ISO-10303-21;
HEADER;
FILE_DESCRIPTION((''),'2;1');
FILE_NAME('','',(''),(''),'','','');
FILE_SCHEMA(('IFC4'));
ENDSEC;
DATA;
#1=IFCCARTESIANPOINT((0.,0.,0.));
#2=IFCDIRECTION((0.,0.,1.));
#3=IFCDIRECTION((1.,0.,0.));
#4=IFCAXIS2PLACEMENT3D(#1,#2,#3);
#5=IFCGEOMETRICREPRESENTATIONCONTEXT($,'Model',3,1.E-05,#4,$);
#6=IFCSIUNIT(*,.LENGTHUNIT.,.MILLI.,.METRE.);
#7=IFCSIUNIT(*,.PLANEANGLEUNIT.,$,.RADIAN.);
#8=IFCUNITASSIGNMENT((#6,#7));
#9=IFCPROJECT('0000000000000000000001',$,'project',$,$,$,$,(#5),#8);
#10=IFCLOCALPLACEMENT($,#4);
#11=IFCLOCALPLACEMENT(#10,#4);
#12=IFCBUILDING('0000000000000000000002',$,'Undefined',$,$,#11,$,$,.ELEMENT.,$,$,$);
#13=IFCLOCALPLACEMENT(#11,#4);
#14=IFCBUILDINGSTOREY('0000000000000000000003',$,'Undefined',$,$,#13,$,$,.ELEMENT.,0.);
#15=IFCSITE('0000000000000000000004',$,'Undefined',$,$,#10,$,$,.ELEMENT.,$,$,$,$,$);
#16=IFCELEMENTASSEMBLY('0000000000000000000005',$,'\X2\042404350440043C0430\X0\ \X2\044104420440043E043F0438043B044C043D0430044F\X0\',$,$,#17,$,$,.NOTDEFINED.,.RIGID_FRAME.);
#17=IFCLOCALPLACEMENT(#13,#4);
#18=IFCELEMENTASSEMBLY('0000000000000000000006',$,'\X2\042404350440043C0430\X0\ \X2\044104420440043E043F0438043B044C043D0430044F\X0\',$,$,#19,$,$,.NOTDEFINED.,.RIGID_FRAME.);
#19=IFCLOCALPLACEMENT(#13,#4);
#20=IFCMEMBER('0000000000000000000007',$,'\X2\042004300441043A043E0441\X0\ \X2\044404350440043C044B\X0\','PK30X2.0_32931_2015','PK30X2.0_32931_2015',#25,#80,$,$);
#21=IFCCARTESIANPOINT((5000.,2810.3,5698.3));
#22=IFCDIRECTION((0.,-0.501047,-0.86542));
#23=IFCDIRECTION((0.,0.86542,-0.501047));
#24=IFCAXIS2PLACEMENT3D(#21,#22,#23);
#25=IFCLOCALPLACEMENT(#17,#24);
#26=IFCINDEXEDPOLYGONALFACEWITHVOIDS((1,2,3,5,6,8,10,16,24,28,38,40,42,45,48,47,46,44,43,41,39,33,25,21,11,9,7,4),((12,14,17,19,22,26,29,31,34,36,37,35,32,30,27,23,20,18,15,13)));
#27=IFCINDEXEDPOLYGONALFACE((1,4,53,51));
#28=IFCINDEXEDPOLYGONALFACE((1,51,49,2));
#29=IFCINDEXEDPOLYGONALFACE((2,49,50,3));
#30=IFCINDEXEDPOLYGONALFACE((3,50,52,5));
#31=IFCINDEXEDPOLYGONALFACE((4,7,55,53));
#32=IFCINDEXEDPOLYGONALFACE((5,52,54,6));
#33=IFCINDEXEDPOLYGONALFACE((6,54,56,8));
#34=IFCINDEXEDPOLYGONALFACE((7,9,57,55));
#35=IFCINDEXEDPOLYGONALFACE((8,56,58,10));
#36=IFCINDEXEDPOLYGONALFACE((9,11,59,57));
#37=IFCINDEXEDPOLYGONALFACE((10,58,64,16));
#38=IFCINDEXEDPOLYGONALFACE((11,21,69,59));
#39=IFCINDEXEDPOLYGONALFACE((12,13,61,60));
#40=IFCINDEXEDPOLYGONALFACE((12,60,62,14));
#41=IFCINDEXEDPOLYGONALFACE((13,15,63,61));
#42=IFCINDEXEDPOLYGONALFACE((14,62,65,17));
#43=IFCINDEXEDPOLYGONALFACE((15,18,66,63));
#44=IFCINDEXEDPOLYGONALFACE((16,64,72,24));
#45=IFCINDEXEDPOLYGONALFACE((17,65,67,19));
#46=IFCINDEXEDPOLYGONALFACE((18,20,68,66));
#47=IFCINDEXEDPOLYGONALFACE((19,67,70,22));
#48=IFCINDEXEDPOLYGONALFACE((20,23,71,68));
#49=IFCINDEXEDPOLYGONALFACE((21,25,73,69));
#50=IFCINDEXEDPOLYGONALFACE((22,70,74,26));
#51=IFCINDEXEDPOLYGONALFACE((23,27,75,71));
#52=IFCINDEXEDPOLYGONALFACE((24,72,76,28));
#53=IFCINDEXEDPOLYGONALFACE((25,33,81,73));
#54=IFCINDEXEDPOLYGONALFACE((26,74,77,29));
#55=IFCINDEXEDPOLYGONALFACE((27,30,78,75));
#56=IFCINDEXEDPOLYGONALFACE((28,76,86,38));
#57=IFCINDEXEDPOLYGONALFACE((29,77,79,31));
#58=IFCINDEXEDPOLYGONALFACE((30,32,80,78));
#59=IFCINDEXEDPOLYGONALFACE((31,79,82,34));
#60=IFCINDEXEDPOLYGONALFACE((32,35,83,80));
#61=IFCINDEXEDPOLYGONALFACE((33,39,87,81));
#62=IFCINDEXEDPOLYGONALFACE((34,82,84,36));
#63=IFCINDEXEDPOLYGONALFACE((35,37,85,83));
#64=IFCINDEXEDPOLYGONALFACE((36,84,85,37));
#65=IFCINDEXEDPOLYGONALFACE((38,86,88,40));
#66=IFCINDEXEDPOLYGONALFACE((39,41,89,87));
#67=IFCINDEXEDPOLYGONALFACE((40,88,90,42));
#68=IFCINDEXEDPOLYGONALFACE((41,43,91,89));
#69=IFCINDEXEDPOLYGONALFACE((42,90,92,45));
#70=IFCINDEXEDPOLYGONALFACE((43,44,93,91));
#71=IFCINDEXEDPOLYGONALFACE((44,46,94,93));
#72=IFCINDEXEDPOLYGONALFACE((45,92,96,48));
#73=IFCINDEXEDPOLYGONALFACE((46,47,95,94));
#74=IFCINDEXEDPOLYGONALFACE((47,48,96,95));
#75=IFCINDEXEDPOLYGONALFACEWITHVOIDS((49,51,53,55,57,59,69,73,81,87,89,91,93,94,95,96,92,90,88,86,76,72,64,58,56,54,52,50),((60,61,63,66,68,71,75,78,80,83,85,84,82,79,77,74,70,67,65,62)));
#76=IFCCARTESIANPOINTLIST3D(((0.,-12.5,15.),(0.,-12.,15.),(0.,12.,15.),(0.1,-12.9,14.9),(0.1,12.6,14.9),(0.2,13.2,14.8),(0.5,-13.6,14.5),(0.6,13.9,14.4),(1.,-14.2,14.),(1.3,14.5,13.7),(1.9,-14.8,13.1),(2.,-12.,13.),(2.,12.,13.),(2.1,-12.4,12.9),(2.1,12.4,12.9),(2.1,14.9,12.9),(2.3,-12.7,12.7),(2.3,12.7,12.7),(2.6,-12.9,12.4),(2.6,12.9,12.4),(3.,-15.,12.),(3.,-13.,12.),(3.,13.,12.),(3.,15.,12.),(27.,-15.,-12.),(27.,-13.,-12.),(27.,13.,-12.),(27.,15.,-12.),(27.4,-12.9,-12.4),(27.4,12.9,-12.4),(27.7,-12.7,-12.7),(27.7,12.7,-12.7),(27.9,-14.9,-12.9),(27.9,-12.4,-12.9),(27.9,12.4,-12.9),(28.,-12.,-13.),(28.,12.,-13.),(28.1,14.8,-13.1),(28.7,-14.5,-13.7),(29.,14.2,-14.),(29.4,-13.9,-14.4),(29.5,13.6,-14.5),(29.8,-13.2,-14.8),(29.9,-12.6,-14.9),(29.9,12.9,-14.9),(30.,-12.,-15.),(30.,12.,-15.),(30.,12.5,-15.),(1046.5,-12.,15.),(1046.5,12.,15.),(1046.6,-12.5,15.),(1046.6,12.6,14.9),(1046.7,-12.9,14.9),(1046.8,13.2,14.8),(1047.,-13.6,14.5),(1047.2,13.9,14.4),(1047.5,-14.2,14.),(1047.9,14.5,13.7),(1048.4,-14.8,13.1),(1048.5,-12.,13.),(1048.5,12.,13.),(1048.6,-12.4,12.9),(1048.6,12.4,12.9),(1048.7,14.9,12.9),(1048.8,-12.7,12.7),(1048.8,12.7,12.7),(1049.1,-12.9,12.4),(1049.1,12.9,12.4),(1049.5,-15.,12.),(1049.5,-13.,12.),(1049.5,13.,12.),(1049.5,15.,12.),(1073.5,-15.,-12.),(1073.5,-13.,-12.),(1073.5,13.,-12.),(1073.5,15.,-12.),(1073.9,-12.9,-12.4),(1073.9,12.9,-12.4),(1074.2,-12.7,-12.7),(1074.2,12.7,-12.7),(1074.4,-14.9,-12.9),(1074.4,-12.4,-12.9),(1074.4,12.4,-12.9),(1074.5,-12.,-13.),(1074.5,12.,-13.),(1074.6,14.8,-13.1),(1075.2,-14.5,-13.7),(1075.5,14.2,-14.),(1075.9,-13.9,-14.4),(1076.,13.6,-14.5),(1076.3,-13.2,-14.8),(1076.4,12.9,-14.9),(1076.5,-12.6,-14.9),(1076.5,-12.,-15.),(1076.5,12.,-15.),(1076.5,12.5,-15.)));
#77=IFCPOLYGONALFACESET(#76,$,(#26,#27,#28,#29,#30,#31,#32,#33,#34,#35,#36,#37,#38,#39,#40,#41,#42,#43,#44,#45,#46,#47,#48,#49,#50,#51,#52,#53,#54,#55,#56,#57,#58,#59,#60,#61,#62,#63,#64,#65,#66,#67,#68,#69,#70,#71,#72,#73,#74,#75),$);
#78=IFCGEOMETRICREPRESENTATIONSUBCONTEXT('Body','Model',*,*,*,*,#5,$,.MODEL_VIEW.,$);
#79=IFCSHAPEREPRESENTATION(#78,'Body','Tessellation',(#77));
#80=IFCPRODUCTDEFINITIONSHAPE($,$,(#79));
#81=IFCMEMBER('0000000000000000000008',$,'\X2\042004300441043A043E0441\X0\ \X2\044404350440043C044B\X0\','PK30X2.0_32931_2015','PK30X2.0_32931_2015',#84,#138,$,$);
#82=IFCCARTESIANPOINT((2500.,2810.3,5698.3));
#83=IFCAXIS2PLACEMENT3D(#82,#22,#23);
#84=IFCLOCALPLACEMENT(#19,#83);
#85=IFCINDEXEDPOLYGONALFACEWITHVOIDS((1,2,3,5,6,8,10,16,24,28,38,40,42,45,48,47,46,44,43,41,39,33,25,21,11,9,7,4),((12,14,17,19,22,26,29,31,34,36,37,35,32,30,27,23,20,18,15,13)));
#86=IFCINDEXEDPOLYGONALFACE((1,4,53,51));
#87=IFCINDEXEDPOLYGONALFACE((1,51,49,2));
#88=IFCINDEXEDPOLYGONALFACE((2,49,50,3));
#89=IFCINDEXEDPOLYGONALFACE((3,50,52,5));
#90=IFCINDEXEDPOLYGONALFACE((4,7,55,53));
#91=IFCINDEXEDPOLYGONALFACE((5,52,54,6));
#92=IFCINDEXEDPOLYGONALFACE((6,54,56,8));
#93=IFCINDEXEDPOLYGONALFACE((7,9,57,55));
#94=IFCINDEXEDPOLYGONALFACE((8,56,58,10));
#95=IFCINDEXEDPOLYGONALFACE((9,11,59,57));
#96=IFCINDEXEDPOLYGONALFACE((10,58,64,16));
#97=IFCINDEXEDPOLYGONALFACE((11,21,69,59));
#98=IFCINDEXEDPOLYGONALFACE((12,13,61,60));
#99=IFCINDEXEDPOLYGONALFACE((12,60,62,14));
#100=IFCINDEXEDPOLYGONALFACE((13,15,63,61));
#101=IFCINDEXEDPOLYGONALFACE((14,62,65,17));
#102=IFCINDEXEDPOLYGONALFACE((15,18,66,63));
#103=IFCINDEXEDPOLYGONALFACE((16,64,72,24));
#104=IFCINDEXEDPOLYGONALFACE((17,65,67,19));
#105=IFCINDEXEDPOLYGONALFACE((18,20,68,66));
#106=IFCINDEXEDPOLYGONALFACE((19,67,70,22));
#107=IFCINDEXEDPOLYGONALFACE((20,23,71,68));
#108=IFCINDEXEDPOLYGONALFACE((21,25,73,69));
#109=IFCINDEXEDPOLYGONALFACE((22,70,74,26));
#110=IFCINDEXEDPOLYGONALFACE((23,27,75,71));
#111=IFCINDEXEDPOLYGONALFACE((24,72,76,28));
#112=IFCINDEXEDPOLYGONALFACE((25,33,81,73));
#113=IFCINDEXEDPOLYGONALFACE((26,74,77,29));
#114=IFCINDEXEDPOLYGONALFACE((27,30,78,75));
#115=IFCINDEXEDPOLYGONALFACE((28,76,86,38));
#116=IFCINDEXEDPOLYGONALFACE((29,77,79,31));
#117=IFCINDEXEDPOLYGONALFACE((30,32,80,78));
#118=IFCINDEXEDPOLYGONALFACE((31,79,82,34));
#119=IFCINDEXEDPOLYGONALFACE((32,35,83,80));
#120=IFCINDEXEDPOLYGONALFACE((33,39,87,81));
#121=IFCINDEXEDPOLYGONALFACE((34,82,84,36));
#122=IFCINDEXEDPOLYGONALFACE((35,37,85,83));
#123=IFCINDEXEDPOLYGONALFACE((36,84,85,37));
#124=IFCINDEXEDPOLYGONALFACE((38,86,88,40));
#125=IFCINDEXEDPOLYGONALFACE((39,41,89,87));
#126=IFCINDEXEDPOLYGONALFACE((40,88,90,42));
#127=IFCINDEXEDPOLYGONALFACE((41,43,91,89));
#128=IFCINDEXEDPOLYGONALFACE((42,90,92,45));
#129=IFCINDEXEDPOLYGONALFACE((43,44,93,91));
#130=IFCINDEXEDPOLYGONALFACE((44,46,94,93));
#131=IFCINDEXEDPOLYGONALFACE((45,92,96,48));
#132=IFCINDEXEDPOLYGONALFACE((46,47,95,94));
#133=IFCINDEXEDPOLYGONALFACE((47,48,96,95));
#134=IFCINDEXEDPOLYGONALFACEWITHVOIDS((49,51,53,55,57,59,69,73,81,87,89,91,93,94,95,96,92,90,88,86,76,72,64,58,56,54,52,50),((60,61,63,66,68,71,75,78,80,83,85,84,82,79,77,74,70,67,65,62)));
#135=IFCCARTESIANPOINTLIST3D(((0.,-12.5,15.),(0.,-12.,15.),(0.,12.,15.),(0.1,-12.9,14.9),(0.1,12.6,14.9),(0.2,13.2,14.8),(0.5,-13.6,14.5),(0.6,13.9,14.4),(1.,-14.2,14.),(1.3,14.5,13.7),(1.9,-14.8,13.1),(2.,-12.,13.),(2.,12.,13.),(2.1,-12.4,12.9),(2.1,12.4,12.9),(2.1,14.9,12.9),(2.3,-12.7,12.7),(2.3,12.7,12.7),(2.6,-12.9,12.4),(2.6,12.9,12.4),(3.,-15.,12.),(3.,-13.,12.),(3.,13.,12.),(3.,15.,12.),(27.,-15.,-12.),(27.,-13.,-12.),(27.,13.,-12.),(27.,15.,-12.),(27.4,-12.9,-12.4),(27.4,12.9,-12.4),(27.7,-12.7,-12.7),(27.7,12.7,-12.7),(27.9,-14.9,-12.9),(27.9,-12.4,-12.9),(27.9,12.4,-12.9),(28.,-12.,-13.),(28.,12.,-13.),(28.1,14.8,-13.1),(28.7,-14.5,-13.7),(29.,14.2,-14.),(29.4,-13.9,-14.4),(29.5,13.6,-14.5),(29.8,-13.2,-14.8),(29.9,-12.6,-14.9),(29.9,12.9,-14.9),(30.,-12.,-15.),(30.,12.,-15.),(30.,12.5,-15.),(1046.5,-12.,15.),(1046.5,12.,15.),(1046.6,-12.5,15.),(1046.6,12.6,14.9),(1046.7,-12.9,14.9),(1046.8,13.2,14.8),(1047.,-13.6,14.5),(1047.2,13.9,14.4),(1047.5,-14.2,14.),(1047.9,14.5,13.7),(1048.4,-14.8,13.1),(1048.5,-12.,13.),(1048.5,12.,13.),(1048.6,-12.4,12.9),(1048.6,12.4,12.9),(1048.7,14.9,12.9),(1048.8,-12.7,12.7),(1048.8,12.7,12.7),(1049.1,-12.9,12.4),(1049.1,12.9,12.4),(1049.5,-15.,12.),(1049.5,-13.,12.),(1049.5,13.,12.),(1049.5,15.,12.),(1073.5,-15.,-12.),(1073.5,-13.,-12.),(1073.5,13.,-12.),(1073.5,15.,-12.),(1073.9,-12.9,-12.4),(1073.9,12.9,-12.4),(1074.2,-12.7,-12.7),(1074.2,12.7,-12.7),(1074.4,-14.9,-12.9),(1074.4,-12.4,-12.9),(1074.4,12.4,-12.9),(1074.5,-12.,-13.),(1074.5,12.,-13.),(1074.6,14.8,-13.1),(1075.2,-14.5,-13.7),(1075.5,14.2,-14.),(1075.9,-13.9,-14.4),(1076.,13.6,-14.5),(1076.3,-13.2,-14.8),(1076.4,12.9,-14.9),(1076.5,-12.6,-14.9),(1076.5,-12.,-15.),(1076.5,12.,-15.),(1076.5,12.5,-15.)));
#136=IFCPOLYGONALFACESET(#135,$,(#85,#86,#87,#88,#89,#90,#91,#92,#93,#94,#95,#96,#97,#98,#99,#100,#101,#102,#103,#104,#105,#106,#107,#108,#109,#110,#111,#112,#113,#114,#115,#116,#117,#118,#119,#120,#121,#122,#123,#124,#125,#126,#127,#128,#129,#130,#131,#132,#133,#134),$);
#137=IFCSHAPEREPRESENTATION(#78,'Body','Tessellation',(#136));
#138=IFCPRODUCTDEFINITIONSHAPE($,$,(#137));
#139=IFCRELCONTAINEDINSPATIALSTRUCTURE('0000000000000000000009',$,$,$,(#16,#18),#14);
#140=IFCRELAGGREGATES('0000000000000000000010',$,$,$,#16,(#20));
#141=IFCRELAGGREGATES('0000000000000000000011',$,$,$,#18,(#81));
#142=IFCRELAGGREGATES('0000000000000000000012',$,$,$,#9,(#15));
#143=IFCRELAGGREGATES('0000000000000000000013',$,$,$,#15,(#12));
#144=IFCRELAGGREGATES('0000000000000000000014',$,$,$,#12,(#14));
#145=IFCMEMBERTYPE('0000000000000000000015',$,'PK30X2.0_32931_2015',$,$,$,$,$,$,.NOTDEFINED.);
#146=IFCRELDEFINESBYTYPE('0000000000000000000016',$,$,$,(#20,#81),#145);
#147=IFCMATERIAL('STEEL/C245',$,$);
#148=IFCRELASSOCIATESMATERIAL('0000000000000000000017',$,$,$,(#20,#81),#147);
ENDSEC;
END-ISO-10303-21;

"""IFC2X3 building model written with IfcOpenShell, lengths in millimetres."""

from ifc_helpers import new_model, si_unit, frame, origin_with_axes, origin_2d_with_axis, place, context, subcontext, project, spatial, hollow_rectangle, extrude, clip, halfspace, material, type_object, element, aggregate, save


model = new_model("IFC2X3")

# Units and contexts
model_context = context("Model", 3, precision=1e-05, world=origin_with_axes())
body_context = subcontext(model_context, "Body", "Model", "MODEL_VIEW")
ifc_project = project(units=[si_unit("LENGTHUNIT", "METRE", prefix="MILLI"), si_unit("PLANEANGLEUNIT", "RADIAN")], contexts=[model_context])

# Site, building, storey
site_placement = place(None, origin_with_axes())
site = spatial("IfcSite", under=ifc_project, at=site_placement, Name="Undefined", CompositionType="ELEMENT")
building_placement = place(site_placement, origin_with_axes())
building = spatial("IfcBuilding", under=site, at=building_placement, Name="Undefined", CompositionType="ELEMENT")
storey_placement = place(building_placement, origin_with_axes())
storey = spatial("IfcBuildingStorey", under=building, at=storey_placement, Name="Undefined", CompositionType="ELEMENT", Elevation=0.0)

# Shared definitions
ifc_material_1 = material(Name="STEEL/C245")

# Element assemblies
assembly_1_placement = place(storey_placement, origin_with_axes())
assembly_1 = element("IfcElementAssembly", 1, at=assembly_1_placement, inside=storey, Name="Ферма стропильная", AssemblyPlace="NOTDEFINED", PredefinedType="RIGID_FRAME")
assembly_2_placement = place(storey_placement, origin_with_axes())
assembly_2 = element("IfcElementAssembly", 2, at=assembly_2_placement, inside=storey, Name="Ферма стропильная", AssemblyPlace="NOTDEFINED", PredefinedType="RIGID_FRAME")

# Members
member_type_1 = type_object("IfcMemberType", Name="PK30X2.0_32931_2015", PredefinedType="NOTDEFINED")
member_1_placement = place(assembly_1_placement, frame((5000.0, 2810.3, 5698.3), z_axis=(0.0, -0.501047, -0.86542), x_axis=(0.0, 0.86542, -0.501047)))
member_1 = element("IfcMember", 3, at=member_1_placement, type_object=member_type_1, material=ifc_material_1, Name="Раскос фермы", Description="PK30X2.0_32931_2015", ObjectType="PK30X2.0_32931_2015", context=body_context, shape_type="Clipping", body=[
    clip(clip(extrude(hollow_rectangle(XDim=30.0, YDim=30.0, WallThickness=2.0, InnerFilletRadius=1.0, OuterFilletRadius=3.0, at=origin_2d_with_axis()), frame((1102.9, 0.0, 0.0), z_axis=(-1.0, 0.0, 0.0), x_axis=(0.0, -1.0, 0.0)), (0.0, 0.0, 1.0), 1129.2), halfspace(frame((1060.0, 0.0, 1.5), z_axis=(-0.707107, 0.0, -0.707107), x_axis=(0.0, -1.0, 0.0)), True)), halfspace(frame((34.5, 0.0, -19.5), z_axis=(-0.707107, 0.0, -0.707107), x_axis=(0.0, -1.0, 0.0)), False)),
])
aggregate(assembly_1, [member_1])
member_2_placement = place(assembly_2_placement, frame((2500.0, 2810.3, 5698.3), z_axis=(0.0, -0.501047, -0.86542), x_axis=(0.0, 0.86542, -0.501047)))
member_2 = element("IfcMember", 4, at=member_2_placement, type_object=member_type_1, material=ifc_material_1, Name="Раскос фермы", Description="PK30X2.0_32931_2015", ObjectType="PK30X2.0_32931_2015", context=body_context, shape_type="Clipping", body=[
    clip(clip(extrude(hollow_rectangle(XDim=30.0, YDim=30.0, WallThickness=2.0, InnerFilletRadius=1.0, OuterFilletRadius=3.0, at=origin_2d_with_axis()), frame((1102.9, 0.0, 0.0), z_axis=(-1.0, 0.0, 0.0), x_axis=(0.0, -1.0, 0.0)), (0.0, 0.0, 1.0), 1129.2), halfspace(frame((1060.0, 0.0, 1.5), z_axis=(-0.707107, 0.0, -0.707107), x_axis=(0.0, -1.0, 0.0)), True)), halfspace(frame((34.5, 0.0, -19.5), z_axis=(-0.707107, 0.0, -0.707107), x_axis=(0.0, -1.0, 0.0)), False)),
])
aggregate(assembly_2, [member_2])

save(model, "model.ifc")
